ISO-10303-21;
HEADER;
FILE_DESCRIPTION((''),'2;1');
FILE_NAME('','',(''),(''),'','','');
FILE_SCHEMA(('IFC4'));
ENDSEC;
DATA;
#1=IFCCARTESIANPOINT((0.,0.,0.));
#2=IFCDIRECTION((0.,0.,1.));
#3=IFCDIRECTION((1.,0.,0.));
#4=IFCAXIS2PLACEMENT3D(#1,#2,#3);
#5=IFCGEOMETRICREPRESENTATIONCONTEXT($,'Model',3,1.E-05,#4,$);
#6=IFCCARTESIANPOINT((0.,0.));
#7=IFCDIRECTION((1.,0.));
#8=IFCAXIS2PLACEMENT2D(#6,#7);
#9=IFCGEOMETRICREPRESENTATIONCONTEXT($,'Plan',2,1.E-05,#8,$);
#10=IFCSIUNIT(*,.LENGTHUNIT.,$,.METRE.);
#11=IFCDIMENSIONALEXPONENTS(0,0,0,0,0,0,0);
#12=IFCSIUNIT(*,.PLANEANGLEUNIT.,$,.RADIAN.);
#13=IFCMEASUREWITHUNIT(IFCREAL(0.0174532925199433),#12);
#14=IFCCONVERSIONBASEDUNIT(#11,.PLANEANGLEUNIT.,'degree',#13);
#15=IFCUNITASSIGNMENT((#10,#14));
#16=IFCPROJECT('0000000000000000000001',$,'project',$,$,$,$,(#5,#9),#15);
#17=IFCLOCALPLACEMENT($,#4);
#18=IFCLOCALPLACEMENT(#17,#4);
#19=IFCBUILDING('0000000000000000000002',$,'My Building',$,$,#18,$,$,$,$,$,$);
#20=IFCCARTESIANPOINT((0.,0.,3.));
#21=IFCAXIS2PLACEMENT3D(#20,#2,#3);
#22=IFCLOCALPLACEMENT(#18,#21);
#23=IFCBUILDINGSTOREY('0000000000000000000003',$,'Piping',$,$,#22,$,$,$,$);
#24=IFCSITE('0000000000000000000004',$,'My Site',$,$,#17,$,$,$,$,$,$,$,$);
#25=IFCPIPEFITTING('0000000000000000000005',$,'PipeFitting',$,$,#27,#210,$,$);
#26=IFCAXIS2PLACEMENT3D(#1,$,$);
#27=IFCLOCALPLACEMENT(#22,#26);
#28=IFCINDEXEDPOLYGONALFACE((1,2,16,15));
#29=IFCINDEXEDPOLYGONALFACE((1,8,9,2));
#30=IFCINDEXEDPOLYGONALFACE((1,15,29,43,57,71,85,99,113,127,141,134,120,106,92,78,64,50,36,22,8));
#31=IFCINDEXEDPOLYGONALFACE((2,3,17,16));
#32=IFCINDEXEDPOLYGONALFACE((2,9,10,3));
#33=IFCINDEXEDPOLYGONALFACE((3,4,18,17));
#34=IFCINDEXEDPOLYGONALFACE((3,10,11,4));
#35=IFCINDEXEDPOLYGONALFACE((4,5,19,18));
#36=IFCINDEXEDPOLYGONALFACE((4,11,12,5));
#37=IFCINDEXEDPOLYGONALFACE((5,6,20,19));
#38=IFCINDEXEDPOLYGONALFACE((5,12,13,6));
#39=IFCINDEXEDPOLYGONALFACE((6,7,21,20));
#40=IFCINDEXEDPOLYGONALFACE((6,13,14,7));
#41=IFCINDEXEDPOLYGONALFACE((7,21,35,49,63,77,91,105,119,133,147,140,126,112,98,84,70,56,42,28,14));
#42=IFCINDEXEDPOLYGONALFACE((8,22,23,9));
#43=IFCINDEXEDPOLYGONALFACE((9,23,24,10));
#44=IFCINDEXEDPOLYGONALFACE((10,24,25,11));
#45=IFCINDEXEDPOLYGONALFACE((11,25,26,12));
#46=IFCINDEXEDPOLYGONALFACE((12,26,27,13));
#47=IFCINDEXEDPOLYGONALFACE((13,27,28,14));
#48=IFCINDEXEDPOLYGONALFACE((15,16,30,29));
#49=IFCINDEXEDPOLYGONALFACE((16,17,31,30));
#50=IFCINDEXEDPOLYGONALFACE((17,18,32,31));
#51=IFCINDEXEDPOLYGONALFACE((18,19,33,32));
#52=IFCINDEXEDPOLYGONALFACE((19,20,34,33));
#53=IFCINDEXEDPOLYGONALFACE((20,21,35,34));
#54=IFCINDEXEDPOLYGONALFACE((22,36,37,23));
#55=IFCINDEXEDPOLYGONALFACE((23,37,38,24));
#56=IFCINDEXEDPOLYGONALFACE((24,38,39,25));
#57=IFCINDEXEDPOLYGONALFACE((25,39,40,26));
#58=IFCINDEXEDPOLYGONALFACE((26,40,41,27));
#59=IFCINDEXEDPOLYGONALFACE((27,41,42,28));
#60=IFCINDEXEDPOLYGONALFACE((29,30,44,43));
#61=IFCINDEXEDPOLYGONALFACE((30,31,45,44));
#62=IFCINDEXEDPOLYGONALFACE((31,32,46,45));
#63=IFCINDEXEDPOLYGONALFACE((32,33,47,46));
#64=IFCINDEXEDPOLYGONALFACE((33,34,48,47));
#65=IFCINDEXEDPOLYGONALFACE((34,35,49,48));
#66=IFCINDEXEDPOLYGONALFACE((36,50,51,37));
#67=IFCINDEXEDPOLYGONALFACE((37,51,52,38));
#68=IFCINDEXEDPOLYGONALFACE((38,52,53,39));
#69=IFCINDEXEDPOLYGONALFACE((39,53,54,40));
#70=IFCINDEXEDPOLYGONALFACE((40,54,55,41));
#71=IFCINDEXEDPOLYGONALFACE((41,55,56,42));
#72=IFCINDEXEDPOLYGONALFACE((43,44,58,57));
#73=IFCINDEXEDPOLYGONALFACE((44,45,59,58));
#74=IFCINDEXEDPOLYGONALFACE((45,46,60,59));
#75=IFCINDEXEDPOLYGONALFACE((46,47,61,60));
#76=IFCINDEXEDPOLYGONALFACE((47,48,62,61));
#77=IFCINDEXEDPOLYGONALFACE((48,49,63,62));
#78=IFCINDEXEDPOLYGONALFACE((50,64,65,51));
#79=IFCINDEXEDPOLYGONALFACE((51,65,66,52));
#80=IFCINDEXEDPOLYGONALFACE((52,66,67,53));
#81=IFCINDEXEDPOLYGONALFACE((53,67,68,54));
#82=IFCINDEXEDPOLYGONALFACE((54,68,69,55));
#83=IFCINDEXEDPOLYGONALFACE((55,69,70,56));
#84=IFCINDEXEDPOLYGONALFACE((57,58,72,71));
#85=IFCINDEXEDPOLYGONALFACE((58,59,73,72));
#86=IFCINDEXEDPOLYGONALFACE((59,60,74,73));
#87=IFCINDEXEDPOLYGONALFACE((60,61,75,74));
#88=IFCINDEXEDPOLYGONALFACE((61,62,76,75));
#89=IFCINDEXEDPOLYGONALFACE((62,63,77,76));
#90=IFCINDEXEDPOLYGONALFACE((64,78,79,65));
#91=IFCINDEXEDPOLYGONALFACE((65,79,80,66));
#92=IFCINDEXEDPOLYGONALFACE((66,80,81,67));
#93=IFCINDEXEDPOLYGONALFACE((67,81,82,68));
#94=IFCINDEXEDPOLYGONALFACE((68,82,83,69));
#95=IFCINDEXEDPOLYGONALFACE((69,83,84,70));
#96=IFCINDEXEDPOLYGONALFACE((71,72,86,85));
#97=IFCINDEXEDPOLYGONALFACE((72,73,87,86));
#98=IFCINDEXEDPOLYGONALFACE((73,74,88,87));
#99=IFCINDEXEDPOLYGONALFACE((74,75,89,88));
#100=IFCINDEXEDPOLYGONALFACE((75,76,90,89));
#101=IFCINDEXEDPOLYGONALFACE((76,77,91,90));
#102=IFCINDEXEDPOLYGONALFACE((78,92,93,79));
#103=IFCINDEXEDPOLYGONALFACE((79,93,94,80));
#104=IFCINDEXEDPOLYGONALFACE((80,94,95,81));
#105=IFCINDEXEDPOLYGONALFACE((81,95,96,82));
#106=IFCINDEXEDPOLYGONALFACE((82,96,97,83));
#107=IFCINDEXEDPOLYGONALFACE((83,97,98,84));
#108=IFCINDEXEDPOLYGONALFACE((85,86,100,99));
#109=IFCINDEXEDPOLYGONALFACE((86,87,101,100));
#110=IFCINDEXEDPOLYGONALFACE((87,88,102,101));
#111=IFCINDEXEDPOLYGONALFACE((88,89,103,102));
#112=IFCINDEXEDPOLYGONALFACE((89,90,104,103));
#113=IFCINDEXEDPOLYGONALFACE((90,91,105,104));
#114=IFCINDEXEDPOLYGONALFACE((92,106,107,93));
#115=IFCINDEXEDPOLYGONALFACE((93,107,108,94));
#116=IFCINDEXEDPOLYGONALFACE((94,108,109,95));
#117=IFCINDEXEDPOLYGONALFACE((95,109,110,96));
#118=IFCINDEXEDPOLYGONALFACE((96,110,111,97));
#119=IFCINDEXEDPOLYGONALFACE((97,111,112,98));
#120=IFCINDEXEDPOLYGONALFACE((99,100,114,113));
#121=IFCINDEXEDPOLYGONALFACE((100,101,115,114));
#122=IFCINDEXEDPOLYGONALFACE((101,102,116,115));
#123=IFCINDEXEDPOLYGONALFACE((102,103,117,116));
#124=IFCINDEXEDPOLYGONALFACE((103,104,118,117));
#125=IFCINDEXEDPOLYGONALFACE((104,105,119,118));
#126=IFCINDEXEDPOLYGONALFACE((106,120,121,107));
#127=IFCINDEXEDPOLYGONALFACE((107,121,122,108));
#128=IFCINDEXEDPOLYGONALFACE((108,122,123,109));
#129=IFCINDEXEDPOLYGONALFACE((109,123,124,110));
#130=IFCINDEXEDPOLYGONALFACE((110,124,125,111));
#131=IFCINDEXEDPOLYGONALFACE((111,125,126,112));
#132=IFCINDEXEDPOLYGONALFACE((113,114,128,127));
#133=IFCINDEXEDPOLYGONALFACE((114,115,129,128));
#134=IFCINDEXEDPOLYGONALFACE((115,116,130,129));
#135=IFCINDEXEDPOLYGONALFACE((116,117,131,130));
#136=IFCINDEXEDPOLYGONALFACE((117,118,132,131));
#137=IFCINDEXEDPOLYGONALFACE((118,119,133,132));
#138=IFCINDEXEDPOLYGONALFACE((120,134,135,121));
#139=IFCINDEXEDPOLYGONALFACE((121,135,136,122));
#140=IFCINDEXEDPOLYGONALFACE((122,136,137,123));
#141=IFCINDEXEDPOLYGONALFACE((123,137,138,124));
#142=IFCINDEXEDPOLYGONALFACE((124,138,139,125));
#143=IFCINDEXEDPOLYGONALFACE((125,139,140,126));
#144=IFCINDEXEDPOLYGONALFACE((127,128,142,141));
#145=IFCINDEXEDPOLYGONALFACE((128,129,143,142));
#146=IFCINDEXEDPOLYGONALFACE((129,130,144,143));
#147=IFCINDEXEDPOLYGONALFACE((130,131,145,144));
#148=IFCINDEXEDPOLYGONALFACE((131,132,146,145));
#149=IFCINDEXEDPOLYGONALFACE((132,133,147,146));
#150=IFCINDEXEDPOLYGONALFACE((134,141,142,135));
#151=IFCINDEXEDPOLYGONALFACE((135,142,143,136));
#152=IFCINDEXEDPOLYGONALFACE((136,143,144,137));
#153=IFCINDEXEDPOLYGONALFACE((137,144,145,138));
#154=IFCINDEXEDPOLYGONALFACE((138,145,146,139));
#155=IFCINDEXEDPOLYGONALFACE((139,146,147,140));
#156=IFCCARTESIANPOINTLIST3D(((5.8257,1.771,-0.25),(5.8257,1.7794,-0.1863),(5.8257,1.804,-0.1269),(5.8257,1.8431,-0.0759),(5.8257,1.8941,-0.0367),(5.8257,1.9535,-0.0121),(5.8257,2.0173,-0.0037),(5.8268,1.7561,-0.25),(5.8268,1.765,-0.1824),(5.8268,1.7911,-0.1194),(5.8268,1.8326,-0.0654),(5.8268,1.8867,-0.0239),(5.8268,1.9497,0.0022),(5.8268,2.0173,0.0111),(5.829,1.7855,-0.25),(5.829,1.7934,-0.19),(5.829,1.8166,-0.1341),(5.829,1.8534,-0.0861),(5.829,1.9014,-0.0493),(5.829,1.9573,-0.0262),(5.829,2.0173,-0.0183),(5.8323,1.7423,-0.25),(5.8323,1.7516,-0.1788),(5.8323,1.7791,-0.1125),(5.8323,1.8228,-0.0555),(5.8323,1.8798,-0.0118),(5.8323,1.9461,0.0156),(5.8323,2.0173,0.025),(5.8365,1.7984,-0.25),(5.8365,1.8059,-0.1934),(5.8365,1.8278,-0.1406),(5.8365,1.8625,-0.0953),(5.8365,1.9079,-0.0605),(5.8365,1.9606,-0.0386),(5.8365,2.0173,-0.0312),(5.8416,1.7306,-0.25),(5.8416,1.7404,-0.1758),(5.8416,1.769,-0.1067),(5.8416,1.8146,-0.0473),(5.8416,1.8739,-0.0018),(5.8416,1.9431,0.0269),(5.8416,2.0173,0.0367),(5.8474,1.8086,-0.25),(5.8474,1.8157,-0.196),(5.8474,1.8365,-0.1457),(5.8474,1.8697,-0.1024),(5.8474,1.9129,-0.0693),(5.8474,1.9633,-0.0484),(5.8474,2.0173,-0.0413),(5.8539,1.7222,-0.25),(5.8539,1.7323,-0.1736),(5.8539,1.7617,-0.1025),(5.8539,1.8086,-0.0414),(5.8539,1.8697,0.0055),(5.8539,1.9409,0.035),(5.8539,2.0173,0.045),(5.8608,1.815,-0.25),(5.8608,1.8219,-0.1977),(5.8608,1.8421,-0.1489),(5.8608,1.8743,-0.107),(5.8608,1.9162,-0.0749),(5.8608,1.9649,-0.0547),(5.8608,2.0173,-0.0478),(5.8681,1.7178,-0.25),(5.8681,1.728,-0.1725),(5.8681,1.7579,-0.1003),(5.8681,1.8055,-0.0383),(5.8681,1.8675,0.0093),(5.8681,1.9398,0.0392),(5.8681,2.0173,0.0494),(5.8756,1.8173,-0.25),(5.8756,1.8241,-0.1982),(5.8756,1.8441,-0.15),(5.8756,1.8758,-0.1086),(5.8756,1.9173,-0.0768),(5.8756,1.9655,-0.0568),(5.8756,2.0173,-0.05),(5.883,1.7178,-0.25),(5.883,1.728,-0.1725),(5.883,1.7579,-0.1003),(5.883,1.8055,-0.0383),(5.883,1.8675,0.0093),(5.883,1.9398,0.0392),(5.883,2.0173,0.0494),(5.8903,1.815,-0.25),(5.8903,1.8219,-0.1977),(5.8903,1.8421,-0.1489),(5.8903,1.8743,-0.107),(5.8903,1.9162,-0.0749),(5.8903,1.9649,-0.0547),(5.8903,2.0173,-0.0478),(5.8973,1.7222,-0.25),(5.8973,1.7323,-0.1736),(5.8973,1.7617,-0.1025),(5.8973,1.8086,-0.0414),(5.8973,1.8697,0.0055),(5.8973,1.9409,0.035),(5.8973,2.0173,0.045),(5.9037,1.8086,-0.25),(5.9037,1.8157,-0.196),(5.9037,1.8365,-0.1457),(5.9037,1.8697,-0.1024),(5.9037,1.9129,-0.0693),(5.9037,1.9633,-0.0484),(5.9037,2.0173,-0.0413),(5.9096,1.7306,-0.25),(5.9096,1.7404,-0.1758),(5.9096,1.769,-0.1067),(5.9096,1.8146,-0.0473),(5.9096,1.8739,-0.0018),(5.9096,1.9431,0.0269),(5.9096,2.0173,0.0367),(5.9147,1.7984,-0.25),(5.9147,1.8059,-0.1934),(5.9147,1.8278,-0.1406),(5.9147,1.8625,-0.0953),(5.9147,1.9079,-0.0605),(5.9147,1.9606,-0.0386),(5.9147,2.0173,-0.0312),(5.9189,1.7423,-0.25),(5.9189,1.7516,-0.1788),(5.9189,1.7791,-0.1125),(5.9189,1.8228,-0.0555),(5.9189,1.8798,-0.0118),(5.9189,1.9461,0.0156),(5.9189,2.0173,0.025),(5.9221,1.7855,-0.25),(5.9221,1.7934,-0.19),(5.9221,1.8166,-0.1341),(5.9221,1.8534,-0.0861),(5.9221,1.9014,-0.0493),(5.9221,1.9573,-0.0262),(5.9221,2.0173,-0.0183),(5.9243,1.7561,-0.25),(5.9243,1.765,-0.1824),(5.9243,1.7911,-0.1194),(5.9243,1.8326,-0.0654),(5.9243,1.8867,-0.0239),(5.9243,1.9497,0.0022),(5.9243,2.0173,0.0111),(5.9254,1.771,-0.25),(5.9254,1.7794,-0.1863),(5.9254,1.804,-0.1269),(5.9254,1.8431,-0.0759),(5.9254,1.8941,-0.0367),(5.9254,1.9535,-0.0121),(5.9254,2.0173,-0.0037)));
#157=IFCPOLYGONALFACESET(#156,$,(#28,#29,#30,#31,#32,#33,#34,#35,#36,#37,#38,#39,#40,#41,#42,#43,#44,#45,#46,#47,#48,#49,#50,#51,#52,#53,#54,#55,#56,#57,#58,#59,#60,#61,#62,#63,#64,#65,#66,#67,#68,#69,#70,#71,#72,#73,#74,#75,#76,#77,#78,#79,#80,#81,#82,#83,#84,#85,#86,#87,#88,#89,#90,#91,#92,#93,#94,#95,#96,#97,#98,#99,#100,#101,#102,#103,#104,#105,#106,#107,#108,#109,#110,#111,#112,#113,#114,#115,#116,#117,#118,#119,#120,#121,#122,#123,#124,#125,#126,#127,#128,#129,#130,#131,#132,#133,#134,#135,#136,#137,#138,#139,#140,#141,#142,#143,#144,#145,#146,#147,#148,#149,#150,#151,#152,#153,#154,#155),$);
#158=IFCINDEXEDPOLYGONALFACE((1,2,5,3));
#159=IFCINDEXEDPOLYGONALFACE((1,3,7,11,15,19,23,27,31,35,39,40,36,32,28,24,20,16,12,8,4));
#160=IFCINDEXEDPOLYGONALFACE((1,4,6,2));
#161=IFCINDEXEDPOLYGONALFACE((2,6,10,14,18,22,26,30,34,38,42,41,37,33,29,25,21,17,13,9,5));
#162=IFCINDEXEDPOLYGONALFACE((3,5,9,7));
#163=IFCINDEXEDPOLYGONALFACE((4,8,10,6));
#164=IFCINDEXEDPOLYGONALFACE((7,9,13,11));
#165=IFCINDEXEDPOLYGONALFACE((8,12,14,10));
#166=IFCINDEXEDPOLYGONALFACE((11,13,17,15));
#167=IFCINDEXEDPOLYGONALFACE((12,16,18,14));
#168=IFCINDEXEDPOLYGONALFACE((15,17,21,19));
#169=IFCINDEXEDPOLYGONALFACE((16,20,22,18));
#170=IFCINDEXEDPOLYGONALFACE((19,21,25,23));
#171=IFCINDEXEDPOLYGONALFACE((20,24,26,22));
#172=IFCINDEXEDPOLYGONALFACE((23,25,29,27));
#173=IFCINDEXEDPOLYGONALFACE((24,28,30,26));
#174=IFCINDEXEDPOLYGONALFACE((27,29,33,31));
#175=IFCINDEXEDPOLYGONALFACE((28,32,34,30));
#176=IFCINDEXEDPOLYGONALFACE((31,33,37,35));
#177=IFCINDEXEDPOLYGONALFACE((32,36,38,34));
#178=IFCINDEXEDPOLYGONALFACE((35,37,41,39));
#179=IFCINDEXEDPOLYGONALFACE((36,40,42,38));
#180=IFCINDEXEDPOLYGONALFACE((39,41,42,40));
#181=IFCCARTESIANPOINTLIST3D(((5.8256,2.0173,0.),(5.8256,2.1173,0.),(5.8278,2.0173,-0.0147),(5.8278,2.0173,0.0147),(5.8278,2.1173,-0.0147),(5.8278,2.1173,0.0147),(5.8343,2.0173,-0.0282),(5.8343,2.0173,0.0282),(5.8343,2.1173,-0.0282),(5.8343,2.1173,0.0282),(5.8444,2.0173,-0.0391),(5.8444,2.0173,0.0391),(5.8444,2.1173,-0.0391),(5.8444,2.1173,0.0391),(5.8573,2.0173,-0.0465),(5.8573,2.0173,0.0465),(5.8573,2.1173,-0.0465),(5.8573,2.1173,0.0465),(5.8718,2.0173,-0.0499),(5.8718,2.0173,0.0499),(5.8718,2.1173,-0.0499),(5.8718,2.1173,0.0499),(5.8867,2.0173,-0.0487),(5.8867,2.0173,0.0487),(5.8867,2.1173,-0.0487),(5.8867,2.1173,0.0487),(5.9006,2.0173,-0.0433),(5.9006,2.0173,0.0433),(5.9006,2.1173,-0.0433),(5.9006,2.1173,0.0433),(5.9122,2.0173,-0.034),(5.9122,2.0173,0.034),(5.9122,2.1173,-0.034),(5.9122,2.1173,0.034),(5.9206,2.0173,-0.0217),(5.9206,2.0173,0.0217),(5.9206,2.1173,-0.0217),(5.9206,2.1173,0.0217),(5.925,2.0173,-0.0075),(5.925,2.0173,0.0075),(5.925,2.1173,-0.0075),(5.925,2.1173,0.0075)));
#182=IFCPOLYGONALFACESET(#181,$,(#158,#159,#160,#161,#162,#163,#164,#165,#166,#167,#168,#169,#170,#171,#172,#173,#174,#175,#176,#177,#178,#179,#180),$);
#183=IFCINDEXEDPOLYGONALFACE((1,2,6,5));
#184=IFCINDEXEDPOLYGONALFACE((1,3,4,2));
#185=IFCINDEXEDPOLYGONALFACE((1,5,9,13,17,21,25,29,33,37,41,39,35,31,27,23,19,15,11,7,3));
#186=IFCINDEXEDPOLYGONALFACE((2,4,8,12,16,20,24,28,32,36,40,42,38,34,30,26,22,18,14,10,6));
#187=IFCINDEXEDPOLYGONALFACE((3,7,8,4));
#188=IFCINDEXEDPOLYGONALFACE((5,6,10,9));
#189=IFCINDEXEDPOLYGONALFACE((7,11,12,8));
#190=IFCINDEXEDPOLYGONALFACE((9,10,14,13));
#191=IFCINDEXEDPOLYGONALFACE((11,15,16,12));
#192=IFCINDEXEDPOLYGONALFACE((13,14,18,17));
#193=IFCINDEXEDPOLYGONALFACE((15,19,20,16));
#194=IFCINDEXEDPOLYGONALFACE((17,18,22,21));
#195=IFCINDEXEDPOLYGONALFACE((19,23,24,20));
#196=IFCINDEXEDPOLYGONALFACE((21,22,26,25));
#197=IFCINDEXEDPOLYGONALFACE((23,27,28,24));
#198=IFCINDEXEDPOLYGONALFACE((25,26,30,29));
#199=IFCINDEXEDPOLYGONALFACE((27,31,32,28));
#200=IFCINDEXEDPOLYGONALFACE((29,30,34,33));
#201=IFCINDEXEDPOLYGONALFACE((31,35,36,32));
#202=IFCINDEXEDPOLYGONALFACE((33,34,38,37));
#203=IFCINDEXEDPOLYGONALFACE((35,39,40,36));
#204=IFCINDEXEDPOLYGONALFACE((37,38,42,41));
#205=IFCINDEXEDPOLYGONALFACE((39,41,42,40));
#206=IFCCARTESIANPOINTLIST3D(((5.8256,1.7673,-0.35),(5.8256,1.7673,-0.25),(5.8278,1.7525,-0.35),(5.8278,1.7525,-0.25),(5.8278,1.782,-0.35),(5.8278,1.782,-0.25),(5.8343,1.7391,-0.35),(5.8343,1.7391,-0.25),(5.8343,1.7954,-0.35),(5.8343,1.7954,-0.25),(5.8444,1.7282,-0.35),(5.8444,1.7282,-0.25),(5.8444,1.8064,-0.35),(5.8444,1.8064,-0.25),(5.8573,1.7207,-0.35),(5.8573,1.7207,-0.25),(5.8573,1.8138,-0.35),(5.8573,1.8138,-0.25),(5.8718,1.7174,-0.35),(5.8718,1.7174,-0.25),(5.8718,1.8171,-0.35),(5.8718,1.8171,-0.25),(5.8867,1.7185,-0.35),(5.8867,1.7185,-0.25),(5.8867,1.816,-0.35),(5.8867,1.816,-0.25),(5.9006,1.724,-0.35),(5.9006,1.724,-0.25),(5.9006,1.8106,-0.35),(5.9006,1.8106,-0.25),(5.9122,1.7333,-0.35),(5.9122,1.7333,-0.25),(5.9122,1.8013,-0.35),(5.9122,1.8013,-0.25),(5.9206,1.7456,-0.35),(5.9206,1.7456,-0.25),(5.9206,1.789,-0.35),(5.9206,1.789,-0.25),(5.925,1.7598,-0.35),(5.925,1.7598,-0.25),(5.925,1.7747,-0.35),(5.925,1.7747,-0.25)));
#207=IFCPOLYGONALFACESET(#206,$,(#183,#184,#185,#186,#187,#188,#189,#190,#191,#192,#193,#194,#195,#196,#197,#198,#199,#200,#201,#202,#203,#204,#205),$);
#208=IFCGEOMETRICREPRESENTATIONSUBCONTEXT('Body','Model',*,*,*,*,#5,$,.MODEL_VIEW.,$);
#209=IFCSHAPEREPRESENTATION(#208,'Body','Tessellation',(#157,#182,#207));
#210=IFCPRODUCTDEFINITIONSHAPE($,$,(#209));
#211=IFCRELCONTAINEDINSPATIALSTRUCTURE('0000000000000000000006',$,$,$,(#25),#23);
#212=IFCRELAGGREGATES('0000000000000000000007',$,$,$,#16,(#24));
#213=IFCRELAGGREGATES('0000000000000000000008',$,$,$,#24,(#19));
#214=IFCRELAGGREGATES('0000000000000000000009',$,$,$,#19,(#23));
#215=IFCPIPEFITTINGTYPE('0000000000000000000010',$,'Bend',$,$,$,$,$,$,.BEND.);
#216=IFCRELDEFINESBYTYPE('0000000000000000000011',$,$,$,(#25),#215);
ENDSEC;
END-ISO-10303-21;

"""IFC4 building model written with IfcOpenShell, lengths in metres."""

from ifc_helpers import new_model, entity, si_unit, converted_unit, frame, origin_with_axes, origin_2d_with_axis, place, context, subcontext, project, spatial, circle, extrude, source, transform, mapped, type_object, type_shapes, element, save


model = new_model("IFC4")

# Units and contexts
model_context = context("Model", 3, precision=1e-05, world=origin_with_axes())
plan_context = context("Plan", 2, precision=1e-05, world=origin_2d_with_axis())
body_context = subcontext(model_context, "Body", "Model", "MODEL_VIEW")
ifc_project = project(units=[si_unit("LENGTHUNIT", "METRE"), converted_unit("PLANEANGLEUNIT", "degree", entity("IfcReal", 0.0174532925199433), si_unit("PLANEANGLEUNIT", "RADIAN"), dimensions=[0, 0, 0, 0, 0, 0, 0])], contexts=[model_context, plan_context])

# Site, building, storey
site_placement = place(None, origin_with_axes())
site = spatial("IfcSite", under=ifc_project, at=site_placement, Name="My Site")
building_placement = place(site_placement, origin_with_axes())
building = spatial("IfcBuilding", under=site, at=building_placement, Name="My Building")
storey_placement = place(building_placement, frame((0.0, 0.0, 3.0), z_axis=(0.0, 0.0, 1.0), x_axis=(1.0, 0.0, 0.0)))
storey = spatial("IfcBuildingStorey", under=building, at=storey_placement, Name="Piping")

# Pipe fitting
pipe_fitting_type = type_object("IfcPipeFittingType", Name="Bend", PredefinedType="BEND")
shared_shape = source(origin_with_axes(), body_context, "Body", "SolidModel", [
    entity("IfcSweptDiskSolid", entity("IfcIndexedPolyCurve", entity("IfcCartesianPointList3D", [[0.0, 0.0, -0.1], [0.0, -0.0732, -0.2768], [0.0, -0.25, -0.35]]), [entity("IfcArcIndex", [1, 2, 3])]), 0.05),
    extrude(circle(Radius=0.05), origin_with_axes(), (0.0, 0.0, -1.0), 0.1),
    extrude(circle(Radius=0.05), frame((0.0, -0.25, -0.35), z_axis=(0.0, -1.0, 0.0), x_axis=(1.0, 0.0, 0.0)), (0.0, 0.0, 1.0), 0.1),
])
type_shapes(pipe_fitting_type, [shared_shape])
for number, where, z_axis, x_axis, name in (
    (1, (5.8756, 2.1173, 0.0), (0.0, 1.0, 0.0), (-1.0, 0.0, 0.0), "PipeFitting"),
):
    element("IfcPipeFitting", number, at=place(storey_placement, frame(where, z_axis=z_axis, x_axis=x_axis)), inside=storey, type_object=pipe_fitting_type, Name=name, context=body_context, shape_type="MappedRepresentation", body=[
        mapped(shared_shape, transform((0.0, 0.0, 0.0), x_axis=(1.0, 0.0, 0.0), y_axis=(0.0, 1.0, 0.0), z_axis=(0.0, 0.0, 1.0), scale=1.0)),
    ])

save(model, "model.ifc")
